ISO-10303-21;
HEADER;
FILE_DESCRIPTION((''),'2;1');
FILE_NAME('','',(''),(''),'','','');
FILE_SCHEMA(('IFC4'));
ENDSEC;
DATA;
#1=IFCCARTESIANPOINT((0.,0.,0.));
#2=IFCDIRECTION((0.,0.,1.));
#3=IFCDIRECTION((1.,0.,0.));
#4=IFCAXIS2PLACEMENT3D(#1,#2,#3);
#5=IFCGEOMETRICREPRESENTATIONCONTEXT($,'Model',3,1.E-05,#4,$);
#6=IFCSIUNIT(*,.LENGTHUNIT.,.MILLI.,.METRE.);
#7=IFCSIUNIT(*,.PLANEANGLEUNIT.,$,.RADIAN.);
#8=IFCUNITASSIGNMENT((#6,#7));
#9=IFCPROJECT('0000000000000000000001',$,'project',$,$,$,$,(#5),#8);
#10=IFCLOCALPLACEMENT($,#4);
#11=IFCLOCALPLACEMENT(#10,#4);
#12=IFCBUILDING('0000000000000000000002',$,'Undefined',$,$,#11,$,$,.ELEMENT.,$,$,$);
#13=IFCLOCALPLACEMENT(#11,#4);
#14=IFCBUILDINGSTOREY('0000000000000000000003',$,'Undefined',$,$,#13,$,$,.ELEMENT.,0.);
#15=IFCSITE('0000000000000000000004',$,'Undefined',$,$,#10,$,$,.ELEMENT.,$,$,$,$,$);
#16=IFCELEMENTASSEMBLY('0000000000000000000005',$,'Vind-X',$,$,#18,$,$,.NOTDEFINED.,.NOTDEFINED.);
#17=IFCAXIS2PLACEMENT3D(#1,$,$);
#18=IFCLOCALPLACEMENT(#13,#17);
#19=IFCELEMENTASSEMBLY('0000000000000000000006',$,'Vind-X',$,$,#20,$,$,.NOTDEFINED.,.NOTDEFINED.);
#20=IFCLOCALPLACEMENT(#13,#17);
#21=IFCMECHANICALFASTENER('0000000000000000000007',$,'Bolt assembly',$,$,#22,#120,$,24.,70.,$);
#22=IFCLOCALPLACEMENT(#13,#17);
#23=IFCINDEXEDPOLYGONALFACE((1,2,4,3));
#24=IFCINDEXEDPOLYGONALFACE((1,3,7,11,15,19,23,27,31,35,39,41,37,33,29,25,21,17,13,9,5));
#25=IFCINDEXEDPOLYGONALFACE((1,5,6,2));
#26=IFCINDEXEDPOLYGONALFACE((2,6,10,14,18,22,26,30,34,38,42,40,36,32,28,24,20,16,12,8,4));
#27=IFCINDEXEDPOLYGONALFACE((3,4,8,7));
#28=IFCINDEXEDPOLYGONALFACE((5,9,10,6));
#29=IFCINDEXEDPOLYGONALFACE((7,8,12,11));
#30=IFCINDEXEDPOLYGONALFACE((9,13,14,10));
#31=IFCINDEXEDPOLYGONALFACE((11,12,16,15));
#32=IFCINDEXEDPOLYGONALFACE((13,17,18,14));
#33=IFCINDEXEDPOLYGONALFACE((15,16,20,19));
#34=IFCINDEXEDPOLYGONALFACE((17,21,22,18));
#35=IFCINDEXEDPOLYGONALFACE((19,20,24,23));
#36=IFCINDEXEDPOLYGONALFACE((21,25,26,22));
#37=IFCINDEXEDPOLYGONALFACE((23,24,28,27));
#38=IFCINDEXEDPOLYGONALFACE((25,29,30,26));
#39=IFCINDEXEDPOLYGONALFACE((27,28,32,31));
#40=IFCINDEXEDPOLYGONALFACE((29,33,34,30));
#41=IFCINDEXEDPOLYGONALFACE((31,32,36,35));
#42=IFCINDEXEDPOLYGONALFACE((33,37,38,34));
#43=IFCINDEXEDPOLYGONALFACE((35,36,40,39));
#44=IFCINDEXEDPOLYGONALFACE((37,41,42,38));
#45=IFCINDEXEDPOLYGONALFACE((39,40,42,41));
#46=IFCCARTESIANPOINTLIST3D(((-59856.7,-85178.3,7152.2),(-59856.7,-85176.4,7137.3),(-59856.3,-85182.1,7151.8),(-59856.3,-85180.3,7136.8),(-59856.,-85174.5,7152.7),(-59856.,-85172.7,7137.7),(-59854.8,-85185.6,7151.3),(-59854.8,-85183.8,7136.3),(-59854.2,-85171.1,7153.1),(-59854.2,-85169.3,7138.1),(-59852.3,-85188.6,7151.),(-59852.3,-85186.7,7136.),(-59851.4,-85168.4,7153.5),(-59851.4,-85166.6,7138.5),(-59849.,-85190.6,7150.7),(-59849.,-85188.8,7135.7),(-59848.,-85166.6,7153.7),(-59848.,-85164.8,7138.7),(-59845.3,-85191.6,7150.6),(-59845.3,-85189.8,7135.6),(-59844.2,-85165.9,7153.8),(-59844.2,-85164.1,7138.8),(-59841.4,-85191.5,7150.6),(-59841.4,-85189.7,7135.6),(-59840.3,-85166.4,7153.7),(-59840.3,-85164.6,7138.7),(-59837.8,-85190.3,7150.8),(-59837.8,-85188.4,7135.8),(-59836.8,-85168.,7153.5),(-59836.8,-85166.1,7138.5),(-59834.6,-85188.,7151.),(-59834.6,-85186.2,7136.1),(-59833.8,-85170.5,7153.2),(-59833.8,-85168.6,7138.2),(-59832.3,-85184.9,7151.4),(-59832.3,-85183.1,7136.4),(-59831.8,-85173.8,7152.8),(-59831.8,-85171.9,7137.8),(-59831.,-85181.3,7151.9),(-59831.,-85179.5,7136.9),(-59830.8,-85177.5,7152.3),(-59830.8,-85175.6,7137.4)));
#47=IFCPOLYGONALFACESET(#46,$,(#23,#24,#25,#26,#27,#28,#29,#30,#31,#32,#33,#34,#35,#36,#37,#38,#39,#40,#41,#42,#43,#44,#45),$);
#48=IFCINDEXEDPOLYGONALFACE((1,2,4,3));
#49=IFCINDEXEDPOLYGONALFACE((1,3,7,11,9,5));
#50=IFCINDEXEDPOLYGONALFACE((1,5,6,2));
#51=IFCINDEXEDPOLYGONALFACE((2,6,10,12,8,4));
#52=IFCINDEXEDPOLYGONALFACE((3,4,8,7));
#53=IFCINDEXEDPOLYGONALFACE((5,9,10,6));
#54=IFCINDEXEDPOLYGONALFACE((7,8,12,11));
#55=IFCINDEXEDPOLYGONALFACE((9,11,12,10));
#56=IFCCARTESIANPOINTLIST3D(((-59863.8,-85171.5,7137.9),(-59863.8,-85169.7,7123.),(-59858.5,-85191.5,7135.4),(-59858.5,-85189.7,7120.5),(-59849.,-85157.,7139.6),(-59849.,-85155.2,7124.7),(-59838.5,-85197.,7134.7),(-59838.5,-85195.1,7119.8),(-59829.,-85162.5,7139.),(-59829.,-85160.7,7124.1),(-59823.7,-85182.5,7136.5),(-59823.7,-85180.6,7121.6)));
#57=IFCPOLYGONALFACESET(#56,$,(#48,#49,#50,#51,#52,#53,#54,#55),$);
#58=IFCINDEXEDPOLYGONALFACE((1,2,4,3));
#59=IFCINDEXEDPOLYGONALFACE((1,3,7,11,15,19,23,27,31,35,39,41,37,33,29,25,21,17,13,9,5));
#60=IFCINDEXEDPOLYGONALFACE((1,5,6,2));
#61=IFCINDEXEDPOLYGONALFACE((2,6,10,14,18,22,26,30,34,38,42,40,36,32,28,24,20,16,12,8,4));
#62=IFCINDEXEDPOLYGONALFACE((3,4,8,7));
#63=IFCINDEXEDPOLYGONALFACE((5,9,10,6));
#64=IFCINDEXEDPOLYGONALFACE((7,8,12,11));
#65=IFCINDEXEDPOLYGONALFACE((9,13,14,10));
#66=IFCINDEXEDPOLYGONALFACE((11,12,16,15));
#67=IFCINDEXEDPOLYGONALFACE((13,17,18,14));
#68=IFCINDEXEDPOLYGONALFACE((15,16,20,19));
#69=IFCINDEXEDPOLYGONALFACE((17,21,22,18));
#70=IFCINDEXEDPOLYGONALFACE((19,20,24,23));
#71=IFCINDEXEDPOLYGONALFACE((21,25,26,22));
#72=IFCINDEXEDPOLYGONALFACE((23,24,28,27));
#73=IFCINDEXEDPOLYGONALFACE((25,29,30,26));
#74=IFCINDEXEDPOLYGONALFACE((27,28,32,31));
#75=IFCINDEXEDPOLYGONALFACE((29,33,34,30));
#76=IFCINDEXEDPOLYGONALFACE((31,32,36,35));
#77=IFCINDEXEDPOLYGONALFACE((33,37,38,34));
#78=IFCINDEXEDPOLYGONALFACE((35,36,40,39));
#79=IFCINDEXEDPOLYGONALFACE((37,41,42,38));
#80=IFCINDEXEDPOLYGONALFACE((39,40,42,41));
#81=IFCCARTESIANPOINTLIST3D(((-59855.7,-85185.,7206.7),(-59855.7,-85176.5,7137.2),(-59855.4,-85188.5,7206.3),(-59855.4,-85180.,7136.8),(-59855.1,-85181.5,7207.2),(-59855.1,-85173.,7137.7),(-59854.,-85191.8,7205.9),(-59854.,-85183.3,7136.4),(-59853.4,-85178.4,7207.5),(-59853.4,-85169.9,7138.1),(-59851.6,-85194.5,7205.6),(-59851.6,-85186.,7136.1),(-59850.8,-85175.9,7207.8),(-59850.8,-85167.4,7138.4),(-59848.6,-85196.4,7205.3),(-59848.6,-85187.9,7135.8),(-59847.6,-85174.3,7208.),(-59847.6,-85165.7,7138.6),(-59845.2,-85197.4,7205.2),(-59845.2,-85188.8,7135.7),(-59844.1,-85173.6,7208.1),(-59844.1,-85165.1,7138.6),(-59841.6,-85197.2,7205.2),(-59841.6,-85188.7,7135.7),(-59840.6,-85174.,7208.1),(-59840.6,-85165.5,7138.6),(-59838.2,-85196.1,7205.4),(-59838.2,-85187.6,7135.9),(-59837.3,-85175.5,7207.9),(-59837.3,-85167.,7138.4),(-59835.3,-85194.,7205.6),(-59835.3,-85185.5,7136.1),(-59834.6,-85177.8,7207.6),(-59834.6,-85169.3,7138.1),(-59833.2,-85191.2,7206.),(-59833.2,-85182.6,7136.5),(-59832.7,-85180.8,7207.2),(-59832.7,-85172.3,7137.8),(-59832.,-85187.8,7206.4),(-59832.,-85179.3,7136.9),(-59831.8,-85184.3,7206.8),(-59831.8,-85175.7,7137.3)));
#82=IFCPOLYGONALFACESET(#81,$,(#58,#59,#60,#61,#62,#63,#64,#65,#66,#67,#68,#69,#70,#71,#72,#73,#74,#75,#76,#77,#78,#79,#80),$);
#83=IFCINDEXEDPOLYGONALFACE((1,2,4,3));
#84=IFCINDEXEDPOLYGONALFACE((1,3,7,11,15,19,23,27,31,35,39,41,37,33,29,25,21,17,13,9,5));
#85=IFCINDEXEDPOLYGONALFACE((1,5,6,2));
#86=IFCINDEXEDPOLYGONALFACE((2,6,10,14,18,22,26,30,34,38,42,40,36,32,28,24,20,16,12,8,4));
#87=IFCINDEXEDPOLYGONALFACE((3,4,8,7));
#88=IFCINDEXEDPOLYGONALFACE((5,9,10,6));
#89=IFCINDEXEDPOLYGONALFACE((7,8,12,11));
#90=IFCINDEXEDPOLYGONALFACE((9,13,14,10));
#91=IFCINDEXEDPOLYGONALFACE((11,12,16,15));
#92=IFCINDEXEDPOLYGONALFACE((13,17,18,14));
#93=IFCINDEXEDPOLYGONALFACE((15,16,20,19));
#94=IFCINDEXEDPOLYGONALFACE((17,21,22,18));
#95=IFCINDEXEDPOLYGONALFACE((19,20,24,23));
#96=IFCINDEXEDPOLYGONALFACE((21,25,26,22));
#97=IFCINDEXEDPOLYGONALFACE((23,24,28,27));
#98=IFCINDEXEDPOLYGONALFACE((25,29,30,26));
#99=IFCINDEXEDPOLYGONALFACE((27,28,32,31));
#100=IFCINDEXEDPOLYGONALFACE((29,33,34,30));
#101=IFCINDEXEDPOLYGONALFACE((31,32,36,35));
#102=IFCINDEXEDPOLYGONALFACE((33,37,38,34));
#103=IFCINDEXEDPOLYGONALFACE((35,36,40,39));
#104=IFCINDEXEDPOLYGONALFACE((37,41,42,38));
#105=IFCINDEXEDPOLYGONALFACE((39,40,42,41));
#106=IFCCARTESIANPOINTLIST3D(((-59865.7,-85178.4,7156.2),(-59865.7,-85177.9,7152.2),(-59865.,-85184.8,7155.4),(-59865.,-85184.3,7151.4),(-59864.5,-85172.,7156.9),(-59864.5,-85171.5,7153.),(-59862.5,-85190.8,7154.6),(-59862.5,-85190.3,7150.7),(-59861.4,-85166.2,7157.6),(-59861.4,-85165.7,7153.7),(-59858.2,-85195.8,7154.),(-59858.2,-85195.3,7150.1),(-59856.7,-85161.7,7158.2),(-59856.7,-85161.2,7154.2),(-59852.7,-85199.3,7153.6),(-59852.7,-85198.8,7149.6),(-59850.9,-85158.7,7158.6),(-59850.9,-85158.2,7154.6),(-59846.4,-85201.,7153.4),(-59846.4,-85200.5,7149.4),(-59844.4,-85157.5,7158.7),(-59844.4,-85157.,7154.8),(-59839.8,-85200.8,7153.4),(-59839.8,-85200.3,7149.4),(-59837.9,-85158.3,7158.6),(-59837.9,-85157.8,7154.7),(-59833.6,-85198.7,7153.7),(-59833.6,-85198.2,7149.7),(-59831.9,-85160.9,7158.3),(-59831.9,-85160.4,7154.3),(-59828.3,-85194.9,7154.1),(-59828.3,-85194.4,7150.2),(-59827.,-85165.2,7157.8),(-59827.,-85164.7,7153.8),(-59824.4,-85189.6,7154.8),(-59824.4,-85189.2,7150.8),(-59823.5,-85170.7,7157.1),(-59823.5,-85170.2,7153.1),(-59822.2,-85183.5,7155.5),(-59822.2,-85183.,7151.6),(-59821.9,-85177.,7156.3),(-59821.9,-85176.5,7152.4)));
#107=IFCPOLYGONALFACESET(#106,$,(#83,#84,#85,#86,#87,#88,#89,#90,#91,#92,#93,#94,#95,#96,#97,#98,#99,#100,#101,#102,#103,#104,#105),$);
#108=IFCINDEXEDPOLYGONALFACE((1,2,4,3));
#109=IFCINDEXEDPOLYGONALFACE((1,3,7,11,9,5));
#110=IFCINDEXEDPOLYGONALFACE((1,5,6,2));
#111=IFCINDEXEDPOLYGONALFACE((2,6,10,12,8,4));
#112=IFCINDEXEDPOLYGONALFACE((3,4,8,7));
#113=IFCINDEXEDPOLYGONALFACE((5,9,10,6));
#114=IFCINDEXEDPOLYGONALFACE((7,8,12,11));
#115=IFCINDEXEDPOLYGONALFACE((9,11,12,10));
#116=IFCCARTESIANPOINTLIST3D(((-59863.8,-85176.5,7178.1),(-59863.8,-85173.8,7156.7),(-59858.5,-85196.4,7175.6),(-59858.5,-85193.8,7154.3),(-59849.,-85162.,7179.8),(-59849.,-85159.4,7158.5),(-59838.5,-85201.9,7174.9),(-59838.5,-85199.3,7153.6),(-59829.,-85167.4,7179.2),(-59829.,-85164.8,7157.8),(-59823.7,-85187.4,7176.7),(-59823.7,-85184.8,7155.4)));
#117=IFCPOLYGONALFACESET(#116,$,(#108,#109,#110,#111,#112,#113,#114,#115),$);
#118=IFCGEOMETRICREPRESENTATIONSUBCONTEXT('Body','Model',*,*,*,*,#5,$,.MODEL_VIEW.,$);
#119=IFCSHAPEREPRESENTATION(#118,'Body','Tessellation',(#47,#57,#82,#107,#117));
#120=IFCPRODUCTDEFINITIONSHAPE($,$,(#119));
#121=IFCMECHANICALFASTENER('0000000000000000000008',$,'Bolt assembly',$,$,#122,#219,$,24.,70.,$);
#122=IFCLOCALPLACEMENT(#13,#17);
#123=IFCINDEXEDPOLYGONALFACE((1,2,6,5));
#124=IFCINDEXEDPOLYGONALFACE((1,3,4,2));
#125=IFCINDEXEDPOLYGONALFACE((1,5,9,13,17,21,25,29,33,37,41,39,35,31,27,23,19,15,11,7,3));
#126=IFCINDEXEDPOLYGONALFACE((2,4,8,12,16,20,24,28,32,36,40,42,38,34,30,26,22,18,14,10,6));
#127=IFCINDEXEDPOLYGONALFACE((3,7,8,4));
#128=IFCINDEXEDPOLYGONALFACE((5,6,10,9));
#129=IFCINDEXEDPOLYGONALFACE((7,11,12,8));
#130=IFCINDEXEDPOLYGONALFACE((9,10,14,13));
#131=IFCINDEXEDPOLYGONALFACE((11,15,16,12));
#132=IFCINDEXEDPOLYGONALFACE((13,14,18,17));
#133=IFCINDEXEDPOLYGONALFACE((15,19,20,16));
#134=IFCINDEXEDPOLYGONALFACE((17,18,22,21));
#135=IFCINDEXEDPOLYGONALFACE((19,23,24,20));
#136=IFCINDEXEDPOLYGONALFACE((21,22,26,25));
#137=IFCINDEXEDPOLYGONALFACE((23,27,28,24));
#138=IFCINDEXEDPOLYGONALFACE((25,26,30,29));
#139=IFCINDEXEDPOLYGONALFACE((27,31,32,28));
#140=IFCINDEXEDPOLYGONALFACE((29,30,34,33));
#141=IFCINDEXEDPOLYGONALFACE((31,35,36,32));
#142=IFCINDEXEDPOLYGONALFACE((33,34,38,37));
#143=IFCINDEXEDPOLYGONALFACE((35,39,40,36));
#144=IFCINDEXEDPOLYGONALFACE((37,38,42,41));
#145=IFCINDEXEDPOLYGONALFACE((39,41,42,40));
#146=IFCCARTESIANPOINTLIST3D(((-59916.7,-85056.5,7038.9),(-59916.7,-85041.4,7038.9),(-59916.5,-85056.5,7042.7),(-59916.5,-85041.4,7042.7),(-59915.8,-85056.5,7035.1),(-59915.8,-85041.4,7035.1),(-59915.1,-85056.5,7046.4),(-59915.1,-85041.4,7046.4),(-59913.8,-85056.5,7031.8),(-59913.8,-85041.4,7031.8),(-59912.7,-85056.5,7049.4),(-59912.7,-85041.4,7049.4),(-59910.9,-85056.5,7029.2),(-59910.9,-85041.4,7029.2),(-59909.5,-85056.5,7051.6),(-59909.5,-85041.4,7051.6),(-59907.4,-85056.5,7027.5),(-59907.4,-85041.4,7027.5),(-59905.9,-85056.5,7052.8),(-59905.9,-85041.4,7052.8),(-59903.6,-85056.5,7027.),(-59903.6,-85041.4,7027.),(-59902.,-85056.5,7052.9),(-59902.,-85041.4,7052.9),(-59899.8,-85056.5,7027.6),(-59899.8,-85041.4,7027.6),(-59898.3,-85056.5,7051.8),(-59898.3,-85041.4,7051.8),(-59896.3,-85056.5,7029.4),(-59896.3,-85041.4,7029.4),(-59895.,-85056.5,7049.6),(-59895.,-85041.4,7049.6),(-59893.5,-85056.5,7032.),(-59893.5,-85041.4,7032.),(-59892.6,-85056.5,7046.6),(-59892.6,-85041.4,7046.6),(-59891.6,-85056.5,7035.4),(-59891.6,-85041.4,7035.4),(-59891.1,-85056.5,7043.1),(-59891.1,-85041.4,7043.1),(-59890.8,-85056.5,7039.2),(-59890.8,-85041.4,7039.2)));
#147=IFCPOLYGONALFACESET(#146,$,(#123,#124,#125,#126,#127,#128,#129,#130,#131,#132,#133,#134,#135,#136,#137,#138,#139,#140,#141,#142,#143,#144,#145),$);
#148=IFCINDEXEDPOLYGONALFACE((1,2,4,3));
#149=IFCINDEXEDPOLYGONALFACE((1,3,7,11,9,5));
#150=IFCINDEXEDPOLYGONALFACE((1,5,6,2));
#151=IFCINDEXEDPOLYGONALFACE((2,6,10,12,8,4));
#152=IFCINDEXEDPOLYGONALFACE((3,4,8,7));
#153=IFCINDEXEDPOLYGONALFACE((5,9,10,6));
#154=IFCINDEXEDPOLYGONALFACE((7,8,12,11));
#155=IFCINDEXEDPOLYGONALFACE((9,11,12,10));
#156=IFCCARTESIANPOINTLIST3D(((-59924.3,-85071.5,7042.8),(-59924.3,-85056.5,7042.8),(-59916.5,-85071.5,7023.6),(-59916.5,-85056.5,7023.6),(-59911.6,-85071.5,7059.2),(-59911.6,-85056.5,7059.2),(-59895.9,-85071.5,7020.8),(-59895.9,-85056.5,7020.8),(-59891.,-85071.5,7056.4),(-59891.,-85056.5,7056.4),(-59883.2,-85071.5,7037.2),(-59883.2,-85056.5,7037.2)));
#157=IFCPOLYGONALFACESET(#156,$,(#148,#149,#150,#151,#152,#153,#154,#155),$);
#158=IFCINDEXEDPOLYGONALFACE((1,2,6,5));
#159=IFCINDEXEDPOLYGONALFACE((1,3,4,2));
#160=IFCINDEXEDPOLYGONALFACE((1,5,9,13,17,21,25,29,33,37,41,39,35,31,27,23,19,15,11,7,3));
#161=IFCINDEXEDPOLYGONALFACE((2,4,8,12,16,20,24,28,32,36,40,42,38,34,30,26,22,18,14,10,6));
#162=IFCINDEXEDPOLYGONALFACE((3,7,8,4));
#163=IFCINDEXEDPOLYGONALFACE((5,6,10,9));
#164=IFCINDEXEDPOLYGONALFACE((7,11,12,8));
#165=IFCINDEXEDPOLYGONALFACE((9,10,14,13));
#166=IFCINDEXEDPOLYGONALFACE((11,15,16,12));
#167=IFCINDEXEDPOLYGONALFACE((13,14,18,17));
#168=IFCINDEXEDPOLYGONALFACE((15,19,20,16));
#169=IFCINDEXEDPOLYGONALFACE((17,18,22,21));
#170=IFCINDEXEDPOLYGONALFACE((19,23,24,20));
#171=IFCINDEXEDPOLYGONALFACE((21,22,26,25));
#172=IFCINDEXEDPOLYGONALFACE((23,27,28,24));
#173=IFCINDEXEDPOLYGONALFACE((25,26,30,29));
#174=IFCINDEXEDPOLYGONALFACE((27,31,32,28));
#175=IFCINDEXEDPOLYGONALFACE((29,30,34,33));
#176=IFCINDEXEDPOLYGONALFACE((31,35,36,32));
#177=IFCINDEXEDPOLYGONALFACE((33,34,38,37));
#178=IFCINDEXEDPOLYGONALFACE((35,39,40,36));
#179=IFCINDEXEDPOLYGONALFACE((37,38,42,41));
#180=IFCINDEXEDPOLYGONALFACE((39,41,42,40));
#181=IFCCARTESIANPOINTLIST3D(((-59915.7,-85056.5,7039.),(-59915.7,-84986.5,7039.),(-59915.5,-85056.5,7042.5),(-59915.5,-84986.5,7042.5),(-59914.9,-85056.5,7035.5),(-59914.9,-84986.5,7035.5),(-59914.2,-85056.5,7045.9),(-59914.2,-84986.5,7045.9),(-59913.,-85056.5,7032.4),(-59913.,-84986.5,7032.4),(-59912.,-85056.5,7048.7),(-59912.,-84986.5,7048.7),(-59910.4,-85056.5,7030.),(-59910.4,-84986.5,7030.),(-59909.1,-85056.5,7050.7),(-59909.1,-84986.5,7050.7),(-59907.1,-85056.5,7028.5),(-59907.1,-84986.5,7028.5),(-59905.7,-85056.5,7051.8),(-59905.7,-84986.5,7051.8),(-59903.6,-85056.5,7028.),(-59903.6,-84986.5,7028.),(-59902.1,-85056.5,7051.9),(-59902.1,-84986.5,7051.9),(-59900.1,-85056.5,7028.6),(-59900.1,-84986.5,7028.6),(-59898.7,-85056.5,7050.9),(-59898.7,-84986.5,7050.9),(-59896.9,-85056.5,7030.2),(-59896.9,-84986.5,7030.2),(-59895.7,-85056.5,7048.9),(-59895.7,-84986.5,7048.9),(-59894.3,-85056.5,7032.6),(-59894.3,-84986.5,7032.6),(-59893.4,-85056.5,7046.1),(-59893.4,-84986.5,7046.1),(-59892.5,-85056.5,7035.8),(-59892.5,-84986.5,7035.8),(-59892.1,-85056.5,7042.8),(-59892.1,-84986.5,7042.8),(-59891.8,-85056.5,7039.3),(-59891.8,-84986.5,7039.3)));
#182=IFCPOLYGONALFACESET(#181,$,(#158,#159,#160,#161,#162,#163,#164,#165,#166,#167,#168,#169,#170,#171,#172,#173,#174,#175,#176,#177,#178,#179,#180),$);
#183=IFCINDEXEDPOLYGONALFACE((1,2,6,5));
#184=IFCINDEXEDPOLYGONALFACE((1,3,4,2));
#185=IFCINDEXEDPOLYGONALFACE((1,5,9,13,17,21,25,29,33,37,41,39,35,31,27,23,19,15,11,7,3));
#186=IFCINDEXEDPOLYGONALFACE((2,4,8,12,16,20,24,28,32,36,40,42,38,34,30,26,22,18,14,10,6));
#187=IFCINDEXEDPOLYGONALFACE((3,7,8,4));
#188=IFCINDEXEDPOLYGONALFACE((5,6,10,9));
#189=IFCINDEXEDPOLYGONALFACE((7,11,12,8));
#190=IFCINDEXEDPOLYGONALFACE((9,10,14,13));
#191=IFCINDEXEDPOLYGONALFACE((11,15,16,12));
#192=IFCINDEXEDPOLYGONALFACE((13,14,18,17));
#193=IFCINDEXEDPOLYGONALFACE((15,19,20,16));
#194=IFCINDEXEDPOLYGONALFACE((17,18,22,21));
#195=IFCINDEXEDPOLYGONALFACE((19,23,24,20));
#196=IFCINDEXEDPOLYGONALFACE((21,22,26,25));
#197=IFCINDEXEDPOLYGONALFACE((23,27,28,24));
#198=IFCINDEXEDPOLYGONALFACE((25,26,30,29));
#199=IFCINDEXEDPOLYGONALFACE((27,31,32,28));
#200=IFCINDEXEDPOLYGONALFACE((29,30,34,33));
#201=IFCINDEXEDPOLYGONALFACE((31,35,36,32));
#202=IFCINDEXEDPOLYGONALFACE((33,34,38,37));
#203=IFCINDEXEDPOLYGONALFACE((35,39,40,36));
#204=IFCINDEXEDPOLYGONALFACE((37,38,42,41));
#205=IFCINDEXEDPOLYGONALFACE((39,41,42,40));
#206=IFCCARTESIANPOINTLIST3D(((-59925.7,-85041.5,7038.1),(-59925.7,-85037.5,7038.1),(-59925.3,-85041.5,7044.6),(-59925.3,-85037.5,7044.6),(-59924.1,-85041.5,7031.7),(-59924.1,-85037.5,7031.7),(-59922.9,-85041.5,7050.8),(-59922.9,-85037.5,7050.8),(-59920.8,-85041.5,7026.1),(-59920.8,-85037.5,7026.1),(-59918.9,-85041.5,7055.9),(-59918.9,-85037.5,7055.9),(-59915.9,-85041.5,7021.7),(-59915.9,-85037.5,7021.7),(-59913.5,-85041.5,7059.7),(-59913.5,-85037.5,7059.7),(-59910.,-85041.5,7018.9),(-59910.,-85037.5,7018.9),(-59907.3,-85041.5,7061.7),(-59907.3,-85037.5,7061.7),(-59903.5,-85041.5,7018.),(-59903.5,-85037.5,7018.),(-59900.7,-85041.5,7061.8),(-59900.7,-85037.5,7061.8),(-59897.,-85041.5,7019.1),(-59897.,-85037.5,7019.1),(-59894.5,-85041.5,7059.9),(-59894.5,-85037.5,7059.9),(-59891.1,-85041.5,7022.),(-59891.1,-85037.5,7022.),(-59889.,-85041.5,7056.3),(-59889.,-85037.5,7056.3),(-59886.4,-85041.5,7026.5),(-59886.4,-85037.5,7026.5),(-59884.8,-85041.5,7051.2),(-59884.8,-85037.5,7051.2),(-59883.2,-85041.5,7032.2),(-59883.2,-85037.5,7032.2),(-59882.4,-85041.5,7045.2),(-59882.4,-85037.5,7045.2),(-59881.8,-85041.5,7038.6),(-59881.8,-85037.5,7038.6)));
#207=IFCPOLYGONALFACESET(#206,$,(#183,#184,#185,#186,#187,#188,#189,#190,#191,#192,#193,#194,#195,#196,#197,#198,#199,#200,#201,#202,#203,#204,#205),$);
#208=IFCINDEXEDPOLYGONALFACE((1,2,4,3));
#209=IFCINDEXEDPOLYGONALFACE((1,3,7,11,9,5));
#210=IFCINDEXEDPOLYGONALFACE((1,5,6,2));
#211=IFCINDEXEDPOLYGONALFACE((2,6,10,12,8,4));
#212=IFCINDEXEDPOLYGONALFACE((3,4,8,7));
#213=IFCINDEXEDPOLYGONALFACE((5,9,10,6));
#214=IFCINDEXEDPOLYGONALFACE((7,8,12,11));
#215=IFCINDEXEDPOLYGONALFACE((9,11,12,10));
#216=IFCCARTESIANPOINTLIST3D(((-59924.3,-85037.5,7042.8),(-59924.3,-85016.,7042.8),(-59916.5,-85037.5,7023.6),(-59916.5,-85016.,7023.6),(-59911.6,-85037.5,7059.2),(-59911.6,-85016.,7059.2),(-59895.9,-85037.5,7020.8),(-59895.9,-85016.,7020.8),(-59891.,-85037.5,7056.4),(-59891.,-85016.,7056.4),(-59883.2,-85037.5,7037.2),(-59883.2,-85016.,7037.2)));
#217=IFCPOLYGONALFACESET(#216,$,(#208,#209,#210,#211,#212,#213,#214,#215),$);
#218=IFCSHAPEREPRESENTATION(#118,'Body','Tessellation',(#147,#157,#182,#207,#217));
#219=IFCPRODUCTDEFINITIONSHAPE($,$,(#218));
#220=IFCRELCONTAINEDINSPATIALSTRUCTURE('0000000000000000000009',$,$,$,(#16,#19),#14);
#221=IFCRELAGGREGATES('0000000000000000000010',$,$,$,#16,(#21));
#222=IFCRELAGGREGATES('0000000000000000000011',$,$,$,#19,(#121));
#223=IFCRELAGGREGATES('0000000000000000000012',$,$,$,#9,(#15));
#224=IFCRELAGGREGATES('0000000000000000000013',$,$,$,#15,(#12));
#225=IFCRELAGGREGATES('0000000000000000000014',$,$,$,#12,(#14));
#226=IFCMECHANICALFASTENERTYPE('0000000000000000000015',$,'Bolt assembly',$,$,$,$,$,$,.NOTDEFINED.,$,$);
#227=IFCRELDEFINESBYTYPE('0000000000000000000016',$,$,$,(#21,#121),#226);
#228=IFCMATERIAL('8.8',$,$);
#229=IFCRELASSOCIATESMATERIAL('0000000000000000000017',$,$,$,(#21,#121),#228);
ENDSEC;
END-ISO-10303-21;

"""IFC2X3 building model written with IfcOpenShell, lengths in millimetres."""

from ifc_helpers import new_model, si_unit, frame, origin_with_axes, origin_2d_with_axis, place, context, subcontext, project, spatial, polyline, circle, outline, extrude, source, transform, mapped, material, type_object, element, aggregate, save


model = new_model("IFC2X3")

# Units and contexts
model_context = context("Model", 3, precision=1e-05, world=origin_with_axes())
body_context = subcontext(model_context, "Body", "Model", "MODEL_VIEW")
ifc_project = project(units=[si_unit("LENGTHUNIT", "METRE", prefix="MILLI"), si_unit("PLANEANGLEUNIT", "RADIAN")], contexts=[model_context])

# Site, building, storey
site_placement = place(None, origin_with_axes())
site = spatial("IfcSite", under=ifc_project, at=site_placement, Name="Undefined", CompositionType="ELEMENT")
building_placement = place(site_placement, origin_with_axes())
building = spatial("IfcBuilding", under=site, at=building_placement, Name="Undefined", CompositionType="ELEMENT")
storey_placement = place(building_placement, origin_with_axes())
storey = spatial("IfcBuildingStorey", under=building, at=storey_placement, Name="Undefined", CompositionType="ELEMENT", Elevation=0.0)

# Element assembly
assembly_1_placement = place(storey_placement, origin_with_axes())
assembly_1 = element("IfcElementAssembly", 1, at=assembly_1_placement, inside=storey, Name="Vind-X", AssemblyPlace="NOTDEFINED", PredefinedType="NOTDEFINED")

# Element assembly
assembly_2_placement = place(storey_placement, origin_with_axes())
assembly_2 = element("IfcElementAssembly", 2, at=assembly_2_placement, inside=storey, Name="Vind-X", AssemblyPlace="NOTDEFINED", PredefinedType="NOTDEFINED")

# Mechanical fasteners
ifc_material_1 = material(Name="8.8")
mechanical_fastener_type = type_object("IfcMechanicalFastenerType", Name="Bolt assembly")
shared_shape_1 = source(origin_with_axes(), body_context, "Body", "SweptSolid", [
    extrude(circle(Radius=13.0, at=origin_2d_with_axis()), frame((0.0, 0.0, 0.0), z_axis=(0.0, 1.0, 0.0), x_axis=(1.0, 0.0, 0.0)), (0.0, 0.0, 1.0), 15.1),
    extrude(outline(polyline([(18.0, -10.4), (18.0, 10.4), (0.0, 20.8), (-18.0, 10.4), (-18.0, -10.4), (0.0, -20.8), (18.0, -10.4)])), frame((0.0, -15.0, 0.0), z_axis=(0.0, 1.0, 0.0), x_axis=(1.0, 0.0, 0.0)), (0.0, 0.0, 1.0), 15.0),
    extrude(circle(Radius=12.0, at=origin_2d_with_axis()), frame((0.0, 0.0, 0.0), z_axis=(0.0, 1.0, 0.0), x_axis=(1.0, 0.0, 0.0)), (0.0, 0.0, 1.0), 70.0),
    extrude(circle(Radius=22.0, at=origin_2d_with_axis()), frame((0.0, 15.0, 0.0), z_axis=(0.0, 1.0, 0.0), x_axis=(1.0, 0.0, 0.0)), (0.0, 0.0, 1.0), 4.0),
    extrude(outline(polyline([(18.0, -10.4), (18.0, 10.4), (0.0, 20.8), (-18.0, 10.4), (-18.0, -10.4), (0.0, -20.8), (18.0, -10.4)])), frame((0.0, 19.0, 0.0), z_axis=(0.0, 1.0, 0.0), x_axis=(1.0, 0.0, 0.0)), (0.0, 0.0, 1.0), 21.5),
])
mechanical_fastener_1_placement = place(assembly_1_placement, frame((-59843.8, -85177.0, 7137.2), z_axis=(-0.711592, -0.697356, -0.085625), x_axis=(0.702593, -0.706288, -0.086721)))
mechanical_fastener_1 = element("IfcMechanicalFastener", 3, at=mechanical_fastener_1_placement, type_object=mechanical_fastener_type, material=ifc_material_1, Name="Bolt assembly", NominalDiameter=24.0, NominalLength=70.0, context=body_context, shape_type="MappedRepresentation", body=[
    mapped(shared_shape_1, transform((0.0, 0.0, 0.0))),
])
aggregate(assembly_1, [mechanical_fastener_1])
mechanical_fastener_2_placement = place(assembly_2_placement, frame((-59903.7, -85056.5, 7040.0), z_axis=(0.613314, 0.0, 0.789839), x_axis=(0.789839, 0.0, -0.613314)))
mechanical_fastener_2 = element("IfcMechanicalFastener", 4, at=mechanical_fastener_2_placement, type_object=mechanical_fastener_type, material=ifc_material_1, Name="Bolt assembly", NominalDiameter=24.0, NominalLength=70.0, context=body_context, shape_type="MappedRepresentation", body=[
    mapped(shared_shape_1, transform((0.0, 0.0, 0.0))),
])
aggregate(assembly_2, [mechanical_fastener_2])

save(model, "model.ifc")
